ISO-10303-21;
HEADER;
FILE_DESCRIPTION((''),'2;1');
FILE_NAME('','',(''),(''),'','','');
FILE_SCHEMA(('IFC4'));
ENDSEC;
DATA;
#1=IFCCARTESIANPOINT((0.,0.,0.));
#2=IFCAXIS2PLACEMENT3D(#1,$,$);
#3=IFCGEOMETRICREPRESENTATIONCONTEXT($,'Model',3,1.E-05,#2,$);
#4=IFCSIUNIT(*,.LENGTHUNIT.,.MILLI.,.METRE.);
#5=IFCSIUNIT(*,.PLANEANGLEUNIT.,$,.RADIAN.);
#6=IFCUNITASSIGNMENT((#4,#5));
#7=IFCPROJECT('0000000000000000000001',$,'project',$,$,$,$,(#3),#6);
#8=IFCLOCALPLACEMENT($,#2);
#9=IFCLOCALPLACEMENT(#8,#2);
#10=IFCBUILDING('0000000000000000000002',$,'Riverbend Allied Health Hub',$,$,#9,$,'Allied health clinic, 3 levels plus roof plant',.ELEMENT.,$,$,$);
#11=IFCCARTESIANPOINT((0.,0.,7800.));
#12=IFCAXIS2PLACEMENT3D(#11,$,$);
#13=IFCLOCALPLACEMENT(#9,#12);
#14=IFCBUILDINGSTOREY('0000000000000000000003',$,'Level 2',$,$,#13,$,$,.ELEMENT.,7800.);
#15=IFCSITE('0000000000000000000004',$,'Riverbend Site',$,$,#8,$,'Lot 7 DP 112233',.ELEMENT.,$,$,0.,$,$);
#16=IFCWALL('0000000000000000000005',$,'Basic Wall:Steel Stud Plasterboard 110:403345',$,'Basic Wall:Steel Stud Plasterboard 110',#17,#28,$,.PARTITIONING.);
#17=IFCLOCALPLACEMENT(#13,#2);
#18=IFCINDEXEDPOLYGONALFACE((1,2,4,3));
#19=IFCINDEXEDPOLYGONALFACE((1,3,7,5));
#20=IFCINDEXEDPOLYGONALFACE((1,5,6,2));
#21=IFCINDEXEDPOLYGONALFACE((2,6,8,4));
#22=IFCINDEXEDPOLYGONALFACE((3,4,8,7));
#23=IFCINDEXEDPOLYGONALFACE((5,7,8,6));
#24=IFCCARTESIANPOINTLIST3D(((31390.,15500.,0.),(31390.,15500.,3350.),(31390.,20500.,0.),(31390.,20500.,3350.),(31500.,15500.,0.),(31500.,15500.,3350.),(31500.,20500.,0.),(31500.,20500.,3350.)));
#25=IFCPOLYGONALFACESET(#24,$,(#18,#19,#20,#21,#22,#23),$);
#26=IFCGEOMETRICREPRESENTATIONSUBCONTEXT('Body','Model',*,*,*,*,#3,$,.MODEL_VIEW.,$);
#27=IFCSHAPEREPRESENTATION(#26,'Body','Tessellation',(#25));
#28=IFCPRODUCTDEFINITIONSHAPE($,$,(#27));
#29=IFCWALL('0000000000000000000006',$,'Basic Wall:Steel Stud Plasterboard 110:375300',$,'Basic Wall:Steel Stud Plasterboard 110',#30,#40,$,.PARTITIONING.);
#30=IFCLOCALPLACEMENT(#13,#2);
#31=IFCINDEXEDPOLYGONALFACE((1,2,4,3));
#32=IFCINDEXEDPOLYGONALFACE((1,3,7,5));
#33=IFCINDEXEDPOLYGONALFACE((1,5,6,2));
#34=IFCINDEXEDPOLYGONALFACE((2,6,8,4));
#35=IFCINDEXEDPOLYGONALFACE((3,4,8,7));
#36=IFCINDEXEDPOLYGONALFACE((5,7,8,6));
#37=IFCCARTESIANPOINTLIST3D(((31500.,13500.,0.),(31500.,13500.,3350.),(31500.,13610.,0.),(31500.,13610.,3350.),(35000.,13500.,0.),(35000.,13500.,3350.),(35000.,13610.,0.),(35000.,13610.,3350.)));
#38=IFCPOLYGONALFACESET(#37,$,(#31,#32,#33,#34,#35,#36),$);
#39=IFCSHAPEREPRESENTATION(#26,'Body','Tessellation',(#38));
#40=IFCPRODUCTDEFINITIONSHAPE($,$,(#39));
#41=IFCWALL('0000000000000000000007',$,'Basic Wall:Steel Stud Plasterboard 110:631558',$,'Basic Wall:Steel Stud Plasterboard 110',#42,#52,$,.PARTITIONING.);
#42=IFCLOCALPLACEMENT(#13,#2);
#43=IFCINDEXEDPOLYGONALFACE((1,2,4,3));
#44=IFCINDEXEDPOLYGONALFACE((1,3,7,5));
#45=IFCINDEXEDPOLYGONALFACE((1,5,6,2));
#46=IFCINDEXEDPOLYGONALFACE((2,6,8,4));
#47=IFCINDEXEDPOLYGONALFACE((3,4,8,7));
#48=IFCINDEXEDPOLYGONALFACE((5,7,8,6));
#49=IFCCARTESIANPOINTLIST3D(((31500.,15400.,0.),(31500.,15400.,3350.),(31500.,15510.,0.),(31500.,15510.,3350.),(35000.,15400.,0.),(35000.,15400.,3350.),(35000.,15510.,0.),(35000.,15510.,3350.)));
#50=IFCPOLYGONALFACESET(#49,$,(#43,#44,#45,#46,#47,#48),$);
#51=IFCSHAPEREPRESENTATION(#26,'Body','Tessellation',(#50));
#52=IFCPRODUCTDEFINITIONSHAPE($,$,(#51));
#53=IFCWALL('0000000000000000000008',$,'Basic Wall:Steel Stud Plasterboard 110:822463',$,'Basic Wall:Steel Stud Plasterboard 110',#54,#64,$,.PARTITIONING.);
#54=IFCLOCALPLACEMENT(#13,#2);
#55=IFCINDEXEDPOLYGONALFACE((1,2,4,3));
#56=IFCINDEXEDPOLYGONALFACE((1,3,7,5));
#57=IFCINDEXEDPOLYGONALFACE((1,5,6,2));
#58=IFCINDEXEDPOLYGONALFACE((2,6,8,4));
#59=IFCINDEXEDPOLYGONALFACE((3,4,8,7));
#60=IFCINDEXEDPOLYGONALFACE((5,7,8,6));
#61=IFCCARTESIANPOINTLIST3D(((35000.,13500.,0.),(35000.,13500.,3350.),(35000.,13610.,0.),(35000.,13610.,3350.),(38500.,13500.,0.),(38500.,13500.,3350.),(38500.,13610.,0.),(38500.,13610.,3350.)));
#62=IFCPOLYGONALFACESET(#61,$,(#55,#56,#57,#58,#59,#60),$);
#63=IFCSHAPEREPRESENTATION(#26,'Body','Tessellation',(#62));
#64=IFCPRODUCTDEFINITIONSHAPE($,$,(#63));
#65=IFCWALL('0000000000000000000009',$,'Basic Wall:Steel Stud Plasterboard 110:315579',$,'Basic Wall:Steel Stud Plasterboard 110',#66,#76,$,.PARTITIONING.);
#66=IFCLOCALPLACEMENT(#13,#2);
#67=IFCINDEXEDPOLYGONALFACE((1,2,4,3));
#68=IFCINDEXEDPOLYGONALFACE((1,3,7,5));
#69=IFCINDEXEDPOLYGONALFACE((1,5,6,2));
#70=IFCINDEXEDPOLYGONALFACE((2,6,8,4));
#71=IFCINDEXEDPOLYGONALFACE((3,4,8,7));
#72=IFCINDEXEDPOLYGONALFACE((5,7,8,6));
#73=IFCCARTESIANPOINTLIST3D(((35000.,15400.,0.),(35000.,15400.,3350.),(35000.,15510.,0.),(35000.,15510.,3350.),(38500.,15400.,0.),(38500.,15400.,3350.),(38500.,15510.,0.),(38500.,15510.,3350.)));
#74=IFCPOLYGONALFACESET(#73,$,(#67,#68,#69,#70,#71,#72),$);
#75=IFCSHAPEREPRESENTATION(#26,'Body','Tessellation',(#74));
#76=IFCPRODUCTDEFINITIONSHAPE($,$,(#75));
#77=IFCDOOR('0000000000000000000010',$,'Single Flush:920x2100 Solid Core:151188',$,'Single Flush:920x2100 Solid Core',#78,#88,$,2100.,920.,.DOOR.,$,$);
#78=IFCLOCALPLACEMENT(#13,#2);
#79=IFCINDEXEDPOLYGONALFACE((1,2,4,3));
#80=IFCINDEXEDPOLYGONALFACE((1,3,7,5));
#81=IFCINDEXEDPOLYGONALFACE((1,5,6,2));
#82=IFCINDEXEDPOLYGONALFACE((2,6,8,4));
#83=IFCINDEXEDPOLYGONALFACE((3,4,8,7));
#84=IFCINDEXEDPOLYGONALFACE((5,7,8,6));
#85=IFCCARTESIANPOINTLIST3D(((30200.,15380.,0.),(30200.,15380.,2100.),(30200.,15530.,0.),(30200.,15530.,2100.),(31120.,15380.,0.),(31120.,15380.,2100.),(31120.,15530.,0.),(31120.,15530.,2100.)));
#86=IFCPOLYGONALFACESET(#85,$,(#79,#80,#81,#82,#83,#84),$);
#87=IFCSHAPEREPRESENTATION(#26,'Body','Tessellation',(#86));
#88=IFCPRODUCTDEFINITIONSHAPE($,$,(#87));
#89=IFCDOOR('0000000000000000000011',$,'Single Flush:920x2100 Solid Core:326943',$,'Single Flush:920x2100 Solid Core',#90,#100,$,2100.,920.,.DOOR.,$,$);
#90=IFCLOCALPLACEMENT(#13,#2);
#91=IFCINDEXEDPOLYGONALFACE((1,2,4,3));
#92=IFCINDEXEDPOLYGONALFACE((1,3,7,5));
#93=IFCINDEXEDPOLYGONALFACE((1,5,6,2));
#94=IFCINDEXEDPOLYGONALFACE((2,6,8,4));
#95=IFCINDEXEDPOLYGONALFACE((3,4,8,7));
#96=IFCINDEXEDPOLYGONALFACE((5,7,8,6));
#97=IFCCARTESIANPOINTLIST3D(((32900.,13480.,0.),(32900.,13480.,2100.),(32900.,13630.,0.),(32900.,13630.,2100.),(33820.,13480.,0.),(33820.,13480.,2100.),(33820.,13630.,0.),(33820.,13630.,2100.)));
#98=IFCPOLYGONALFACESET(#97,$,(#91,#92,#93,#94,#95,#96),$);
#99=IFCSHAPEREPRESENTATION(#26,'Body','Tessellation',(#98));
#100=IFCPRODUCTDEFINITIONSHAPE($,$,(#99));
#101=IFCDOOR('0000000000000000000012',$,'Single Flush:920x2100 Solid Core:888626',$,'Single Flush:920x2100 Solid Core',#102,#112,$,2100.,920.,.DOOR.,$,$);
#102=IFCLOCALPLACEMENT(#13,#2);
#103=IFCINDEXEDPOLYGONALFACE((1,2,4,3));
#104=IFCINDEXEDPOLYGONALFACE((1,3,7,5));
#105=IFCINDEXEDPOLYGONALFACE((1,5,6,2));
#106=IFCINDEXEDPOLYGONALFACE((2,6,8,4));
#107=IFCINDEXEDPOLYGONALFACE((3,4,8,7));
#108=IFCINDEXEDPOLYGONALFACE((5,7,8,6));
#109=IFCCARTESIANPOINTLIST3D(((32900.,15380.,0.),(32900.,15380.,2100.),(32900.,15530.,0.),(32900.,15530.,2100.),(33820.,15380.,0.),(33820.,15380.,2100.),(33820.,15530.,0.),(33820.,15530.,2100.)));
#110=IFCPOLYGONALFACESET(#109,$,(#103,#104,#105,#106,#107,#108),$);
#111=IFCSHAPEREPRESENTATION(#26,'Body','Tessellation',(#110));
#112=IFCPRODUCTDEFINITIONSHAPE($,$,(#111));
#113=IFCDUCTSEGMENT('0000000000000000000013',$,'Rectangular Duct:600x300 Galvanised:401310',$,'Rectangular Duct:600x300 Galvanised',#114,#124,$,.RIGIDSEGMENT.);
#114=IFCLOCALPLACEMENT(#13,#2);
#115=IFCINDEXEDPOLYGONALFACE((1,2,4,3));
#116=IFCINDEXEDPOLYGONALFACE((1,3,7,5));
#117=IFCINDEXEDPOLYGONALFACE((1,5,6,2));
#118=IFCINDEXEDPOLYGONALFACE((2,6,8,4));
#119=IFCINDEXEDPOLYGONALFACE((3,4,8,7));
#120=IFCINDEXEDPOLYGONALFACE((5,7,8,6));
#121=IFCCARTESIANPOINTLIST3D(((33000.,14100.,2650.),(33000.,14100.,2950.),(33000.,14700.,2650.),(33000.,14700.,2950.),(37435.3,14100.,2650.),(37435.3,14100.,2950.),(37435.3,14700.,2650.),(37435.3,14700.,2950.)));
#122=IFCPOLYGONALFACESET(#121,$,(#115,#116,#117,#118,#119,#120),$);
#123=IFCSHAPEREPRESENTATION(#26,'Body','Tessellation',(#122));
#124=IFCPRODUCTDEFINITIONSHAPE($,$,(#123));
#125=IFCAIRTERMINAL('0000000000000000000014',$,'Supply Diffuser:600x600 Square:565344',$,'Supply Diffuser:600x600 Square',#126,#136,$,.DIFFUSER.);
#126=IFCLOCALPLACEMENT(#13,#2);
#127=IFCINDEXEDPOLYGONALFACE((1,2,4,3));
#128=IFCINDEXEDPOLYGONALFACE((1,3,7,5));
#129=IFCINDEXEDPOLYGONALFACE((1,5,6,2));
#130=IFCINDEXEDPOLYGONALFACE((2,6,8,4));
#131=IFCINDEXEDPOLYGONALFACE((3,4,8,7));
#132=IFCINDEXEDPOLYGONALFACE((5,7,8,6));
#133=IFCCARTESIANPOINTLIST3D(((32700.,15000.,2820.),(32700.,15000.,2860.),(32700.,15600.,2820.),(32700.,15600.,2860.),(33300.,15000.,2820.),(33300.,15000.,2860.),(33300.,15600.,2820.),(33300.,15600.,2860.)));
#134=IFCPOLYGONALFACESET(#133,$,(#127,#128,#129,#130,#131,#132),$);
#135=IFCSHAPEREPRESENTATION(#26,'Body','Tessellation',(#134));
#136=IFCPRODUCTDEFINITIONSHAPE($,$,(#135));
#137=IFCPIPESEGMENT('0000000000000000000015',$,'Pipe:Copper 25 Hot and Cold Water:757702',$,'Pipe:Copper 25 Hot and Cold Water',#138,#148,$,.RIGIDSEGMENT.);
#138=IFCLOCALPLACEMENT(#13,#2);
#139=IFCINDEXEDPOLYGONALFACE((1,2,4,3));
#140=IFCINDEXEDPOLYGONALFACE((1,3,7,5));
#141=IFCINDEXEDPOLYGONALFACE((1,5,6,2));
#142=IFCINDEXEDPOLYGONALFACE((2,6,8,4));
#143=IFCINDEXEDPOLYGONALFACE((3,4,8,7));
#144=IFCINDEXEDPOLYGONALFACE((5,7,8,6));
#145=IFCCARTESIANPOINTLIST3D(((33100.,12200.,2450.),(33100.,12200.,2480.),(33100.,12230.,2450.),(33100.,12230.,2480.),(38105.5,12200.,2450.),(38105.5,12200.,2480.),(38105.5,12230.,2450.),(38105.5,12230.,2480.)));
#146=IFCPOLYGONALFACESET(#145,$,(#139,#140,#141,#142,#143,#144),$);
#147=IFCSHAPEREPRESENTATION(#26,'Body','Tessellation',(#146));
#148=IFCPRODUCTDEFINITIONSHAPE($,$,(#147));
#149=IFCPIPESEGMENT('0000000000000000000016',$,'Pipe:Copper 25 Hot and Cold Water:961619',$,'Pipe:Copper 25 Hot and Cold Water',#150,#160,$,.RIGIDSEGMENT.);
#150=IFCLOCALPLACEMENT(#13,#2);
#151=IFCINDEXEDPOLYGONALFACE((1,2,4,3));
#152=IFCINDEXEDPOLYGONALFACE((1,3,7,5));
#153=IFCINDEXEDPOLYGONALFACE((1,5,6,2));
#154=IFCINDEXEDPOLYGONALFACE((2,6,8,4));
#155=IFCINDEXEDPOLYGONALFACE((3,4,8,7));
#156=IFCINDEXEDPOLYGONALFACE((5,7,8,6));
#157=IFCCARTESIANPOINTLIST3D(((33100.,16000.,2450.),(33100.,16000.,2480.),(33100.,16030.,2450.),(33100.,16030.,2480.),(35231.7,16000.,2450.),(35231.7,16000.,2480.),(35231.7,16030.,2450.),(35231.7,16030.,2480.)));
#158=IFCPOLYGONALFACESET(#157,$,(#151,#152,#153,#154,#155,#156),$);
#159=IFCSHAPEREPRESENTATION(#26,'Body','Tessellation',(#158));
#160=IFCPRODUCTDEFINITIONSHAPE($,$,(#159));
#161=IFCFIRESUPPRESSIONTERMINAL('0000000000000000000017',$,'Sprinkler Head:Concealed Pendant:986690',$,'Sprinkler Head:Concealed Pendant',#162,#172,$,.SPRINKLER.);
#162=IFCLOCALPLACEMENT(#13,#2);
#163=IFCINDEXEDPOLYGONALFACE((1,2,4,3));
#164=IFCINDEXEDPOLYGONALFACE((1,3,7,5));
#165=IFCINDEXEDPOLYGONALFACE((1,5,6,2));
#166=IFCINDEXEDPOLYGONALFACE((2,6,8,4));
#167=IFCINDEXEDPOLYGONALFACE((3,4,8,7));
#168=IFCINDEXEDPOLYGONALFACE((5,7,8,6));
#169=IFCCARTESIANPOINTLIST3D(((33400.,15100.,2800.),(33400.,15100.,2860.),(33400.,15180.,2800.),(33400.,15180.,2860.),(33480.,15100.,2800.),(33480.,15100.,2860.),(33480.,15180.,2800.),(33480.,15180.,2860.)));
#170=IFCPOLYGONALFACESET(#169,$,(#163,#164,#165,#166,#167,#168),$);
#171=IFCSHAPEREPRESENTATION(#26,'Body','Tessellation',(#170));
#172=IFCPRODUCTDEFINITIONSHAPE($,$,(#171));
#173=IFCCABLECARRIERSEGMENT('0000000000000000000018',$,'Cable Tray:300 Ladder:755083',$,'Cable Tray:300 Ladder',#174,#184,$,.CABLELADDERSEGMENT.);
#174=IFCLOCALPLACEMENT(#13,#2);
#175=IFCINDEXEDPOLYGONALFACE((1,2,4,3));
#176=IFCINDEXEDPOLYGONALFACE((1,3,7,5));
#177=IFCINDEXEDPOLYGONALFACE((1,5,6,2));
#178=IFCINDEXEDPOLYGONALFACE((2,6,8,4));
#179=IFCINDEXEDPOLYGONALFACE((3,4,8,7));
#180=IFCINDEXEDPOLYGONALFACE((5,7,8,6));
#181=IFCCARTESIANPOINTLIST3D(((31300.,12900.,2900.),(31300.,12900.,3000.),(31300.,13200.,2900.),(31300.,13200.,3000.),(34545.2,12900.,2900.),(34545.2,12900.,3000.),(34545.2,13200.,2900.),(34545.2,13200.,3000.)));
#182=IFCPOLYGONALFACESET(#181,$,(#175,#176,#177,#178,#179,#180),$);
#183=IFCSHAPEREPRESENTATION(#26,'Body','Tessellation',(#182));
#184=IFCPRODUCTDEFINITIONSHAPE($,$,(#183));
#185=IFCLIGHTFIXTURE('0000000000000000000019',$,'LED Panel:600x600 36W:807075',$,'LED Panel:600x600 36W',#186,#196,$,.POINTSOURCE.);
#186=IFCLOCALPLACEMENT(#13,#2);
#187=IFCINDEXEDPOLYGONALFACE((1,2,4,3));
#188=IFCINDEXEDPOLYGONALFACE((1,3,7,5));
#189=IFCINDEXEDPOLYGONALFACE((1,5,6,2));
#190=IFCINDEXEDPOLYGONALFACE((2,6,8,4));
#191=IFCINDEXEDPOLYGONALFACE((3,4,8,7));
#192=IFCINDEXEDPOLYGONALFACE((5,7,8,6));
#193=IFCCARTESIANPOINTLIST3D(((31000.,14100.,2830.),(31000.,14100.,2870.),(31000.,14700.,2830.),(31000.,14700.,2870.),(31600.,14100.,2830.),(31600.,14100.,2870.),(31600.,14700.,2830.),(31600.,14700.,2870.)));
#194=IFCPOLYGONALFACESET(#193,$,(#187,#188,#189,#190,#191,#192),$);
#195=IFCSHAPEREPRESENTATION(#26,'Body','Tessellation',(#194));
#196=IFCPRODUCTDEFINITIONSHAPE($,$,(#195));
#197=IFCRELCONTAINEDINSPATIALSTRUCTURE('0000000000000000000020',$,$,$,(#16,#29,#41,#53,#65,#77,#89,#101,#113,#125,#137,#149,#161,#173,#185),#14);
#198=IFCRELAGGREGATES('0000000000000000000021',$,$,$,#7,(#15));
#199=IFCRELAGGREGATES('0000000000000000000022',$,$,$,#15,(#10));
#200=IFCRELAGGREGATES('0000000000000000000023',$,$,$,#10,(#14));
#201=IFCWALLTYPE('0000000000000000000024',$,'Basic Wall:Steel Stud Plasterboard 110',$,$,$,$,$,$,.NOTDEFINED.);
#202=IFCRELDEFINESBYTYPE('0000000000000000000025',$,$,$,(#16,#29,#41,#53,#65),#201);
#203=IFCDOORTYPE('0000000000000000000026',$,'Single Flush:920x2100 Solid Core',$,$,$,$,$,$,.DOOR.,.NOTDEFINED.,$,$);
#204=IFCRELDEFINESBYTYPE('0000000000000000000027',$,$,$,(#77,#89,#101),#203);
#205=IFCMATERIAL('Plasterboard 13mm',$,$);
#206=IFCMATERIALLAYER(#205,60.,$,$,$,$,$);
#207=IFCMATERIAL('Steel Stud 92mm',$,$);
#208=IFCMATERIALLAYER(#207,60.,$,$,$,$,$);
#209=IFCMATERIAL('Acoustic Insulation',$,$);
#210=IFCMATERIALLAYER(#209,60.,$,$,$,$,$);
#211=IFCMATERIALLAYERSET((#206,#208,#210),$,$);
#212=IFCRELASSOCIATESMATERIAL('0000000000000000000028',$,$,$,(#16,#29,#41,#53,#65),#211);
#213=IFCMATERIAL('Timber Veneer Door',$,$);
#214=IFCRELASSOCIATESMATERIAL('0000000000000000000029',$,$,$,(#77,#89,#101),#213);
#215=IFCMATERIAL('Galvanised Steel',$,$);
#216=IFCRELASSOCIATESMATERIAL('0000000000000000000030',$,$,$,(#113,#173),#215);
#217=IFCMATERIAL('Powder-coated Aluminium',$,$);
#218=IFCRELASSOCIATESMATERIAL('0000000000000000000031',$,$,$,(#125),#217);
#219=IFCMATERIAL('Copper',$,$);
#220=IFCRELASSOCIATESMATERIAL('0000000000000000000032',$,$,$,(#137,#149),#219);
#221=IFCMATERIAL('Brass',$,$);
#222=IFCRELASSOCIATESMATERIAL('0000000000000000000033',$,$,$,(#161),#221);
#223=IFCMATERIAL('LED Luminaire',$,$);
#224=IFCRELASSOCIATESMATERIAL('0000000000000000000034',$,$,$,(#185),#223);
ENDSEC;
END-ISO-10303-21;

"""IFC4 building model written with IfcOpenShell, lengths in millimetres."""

from ifc_helpers import new_model, si_unit, frame, frame_2d, origin, place, context, subcontext, project, spatial, rectangle, extrude, material, layer, layer_set, layer_usage, type_object, element, save


model = new_model("IFC4")

# Units and contexts
model_context = context("Model", 3, precision=1e-05, world=origin())
body_context = subcontext(model_context, "Body", "Model", "MODEL_VIEW")
ifc_project = project(units=[si_unit("LENGTHUNIT", "METRE", prefix="MILLI"), si_unit("PLANEANGLEUNIT", "RADIAN")], contexts=[model_context])

# Site, building, storey
site_placement = place(None, origin())
site = spatial("IfcSite", under=ifc_project, at=site_placement, Name="Riverbend Site", LongName="Lot 7 DP 112233", CompositionType="ELEMENT", RefElevation=0.0)
building_placement = place(site_placement, origin())
building = spatial("IfcBuilding", under=site, at=building_placement, Name="Riverbend Allied Health Hub", LongName="Allied health clinic, 3 levels plus roof plant", CompositionType="ELEMENT")
storey_placement = place(building_placement, frame((0.0, 0.0, 7800.0)))
storey = spatial("IfcBuildingStorey", under=building, at=storey_placement, Name="Level 2", CompositionType="ELEMENT", Elevation=7800.0)

# Walls
ifc_material_1 = material(Name="Plasterboard 13mm")
ifc_layer_1 = layer(ifc_material_1, 60.0)
ifc_material_2 = material(Name="Steel Stud 92mm")
ifc_layer_2 = layer(ifc_material_2, 60.0)
ifc_material_3 = material(Name="Acoustic Insulation")
ifc_layer_3 = layer(ifc_material_3, 60.0)
ifc_layer_set = layer_set([ifc_layer_1, ifc_layer_2, ifc_layer_3])
ifc_layer_usage = layer_usage(ifc_layer_set, "AXIS2", "POSITIVE", 0.0)
wall_type = type_object("IfcWallType", Name="Basic Wall:Steel Stud Plasterboard 110", PredefinedType="NOTDEFINED")
wall_placement = place(storey_placement, frame((31500.0, 15500.0, 0.0), z_axis=(0.0, 0.0, 1.0), x_axis=(0.0, 1.0, 0.0)))
element("IfcWall", 1, at=wall_placement, inside=storey, type_object=wall_type, material=ifc_layer_usage, Name="Basic Wall:Steel Stud Plasterboard 110:403345", ObjectType="Basic Wall:Steel Stud Plasterboard 110", PredefinedType="PARTITIONING", context=body_context, shape_type="SweptSolid", body=[
    extrude(rectangle(XDim=5000.0, YDim=110.0, at=frame_2d((2500.0, 55.0))), origin(), (0.0, 0.0, 1.0), 3350.0),
])
for number, where, name in (
    (2, (31500.0, 13500.0, 0.0), "Basic Wall:Steel Stud Plasterboard 110:375300"),
    (3, (31500.0, 15400.0, 0.0), "Basic Wall:Steel Stud Plasterboard 110:631558"),
    (4, (35000.0, 13500.0, 0.0), "Basic Wall:Steel Stud Plasterboard 110:822463"),
    (5, (35000.0, 15400.0, 0.0), "Basic Wall:Steel Stud Plasterboard 110:315579"),
):
    element("IfcWall", number, at=place(storey_placement, frame(where)), inside=storey, type_object=wall_type, material=ifc_layer_usage, Name=name, ObjectType="Basic Wall:Steel Stud Plasterboard 110", PredefinedType="PARTITIONING", context=body_context, shape_type="SweptSolid", body=[
        extrude(rectangle(XDim=3500.0, YDim=110.0, at=frame_2d((1750.0, 55.0))), origin(), (0.0, 0.0, 1.0), 3350.0),
    ])

# Doors
ifc_material_4 = material(Name="Timber Veneer Door")
door_type = type_object("IfcDoorType", Name="Single Flush:920x2100 Solid Core", OperationType="NOTDEFINED", PredefinedType="DOOR")
for number, where, name in (
    (6, (30200.0, 15380.0, 0.0), "Single Flush:920x2100 Solid Core:151188"),
    (7, (32900.0, 13480.0, 0.0), "Single Flush:920x2100 Solid Core:326943"),
    (8, (32900.0, 15380.0, 0.0), "Single Flush:920x2100 Solid Core:888626"),
):
    element("IfcDoor", number, at=place(storey_placement, frame(where)), inside=storey, type_object=door_type, material=ifc_material_4, Name=name, ObjectType="Single Flush:920x2100 Solid Core", OverallHeight=2100.0, OverallWidth=920.0, PredefinedType="DOOR", context=body_context, shape_type="SweptSolid", body=[
        extrude(rectangle(XDim=920.0, YDim=150.0, at=frame_2d((460.0, 75.0))), origin(), (0.0, 0.0, 1.0), 2100.0),
    ])

# Duct segment
ifc_material_5 = material(Name="Galvanised Steel")
duct_segment_placement = place(storey_placement, frame((33000.0, 14100.0, 2650.0)))
element("IfcDuctSegment", 9, at=duct_segment_placement, inside=storey, material=ifc_material_5, Name="Rectangular Duct:600x300 Galvanised:401310", ObjectType="Rectangular Duct:600x300 Galvanised", PredefinedType="RIGIDSEGMENT", context=body_context, shape_type="SweptSolid", body=[
    extrude(rectangle(XDim=4435.3, YDim=600.0, at=frame_2d((2217.6, 300.0))), origin(), (0.0, 0.0, 1.0), 300.0),
])

# Air terminal
ifc_material_6 = material(Name="Powder-coated Aluminium")
air_terminal_placement = place(storey_placement, frame((32700.0, 15000.0, 2820.0)))
element("IfcAirTerminal", 10, at=air_terminal_placement, inside=storey, material=ifc_material_6, Name="Supply Diffuser:600x600 Square:565344", ObjectType="Supply Diffuser:600x600 Square", PredefinedType="DIFFUSER", context=body_context, shape_type="SweptSolid", body=[
    extrude(rectangle(XDim=600.0, YDim=600.0, at=frame_2d((300.0, 300.0))), origin(), (0.0, 0.0, 1.0), 40.0),
])

# Pipe segments
ifc_material_7 = material(Name="Copper")
pipe_segment_1_placement = place(storey_placement, frame((33100.0, 12200.0, 2450.0)))
element("IfcPipeSegment", 11, at=pipe_segment_1_placement, inside=storey, material=ifc_material_7, Name="Pipe:Copper 25 Hot and Cold Water:757702", ObjectType="Pipe:Copper 25 Hot and Cold Water", PredefinedType="RIGIDSEGMENT", context=body_context, shape_type="SweptSolid", body=[
    extrude(rectangle(XDim=5005.5, YDim=30.0, at=frame_2d((2502.8, 15.0))), origin(), (0.0, 0.0, 1.0), 30.0),
])
pipe_segment_2_placement = place(storey_placement, frame((33100.0, 16000.0, 2450.0)))
element("IfcPipeSegment", 12, at=pipe_segment_2_placement, inside=storey, material=ifc_material_7, Name="Pipe:Copper 25 Hot and Cold Water:961619", ObjectType="Pipe:Copper 25 Hot and Cold Water", PredefinedType="RIGIDSEGMENT", context=body_context, shape_type="SweptSolid", body=[
    extrude(rectangle(XDim=2131.7, YDim=30.0, at=frame_2d((1065.8, 15.0))), origin(), (0.0, 0.0, 1.0), 30.0),
])

# Fire suppression terminal
ifc_material_8 = material(Name="Brass")
fire_suppression_terminal_placement = place(storey_placement, frame((33400.0, 15100.0, 2800.0)))
element("IfcFireSuppressionTerminal", 13, at=fire_suppression_terminal_placement, inside=storey, material=ifc_material_8, Name="Sprinkler Head:Concealed Pendant:986690", ObjectType="Sprinkler Head:Concealed Pendant", PredefinedType="SPRINKLER", context=body_context, shape_type="SweptSolid", body=[
    extrude(rectangle(XDim=80.0, YDim=80.0, at=frame_2d((40.0, 40.0))), origin(), (0.0, 0.0, 1.0), 60.0),
])

# Cable carrier segment
cable_carrier_segment_placement = place(storey_placement, frame((31300.0, 12900.0, 2900.0)))
element("IfcCableCarrierSegment", 14, at=cable_carrier_segment_placement, inside=storey, material=ifc_material_5, Name="Cable Tray:300 Ladder:755083", ObjectType="Cable Tray:300 Ladder", PredefinedType="CABLELADDERSEGMENT", context=body_context, shape_type="SweptSolid", body=[
    extrude(rectangle(XDim=3245.2, YDim=300.0, at=frame_2d((1622.6, 150.0))), origin(), (0.0, 0.0, 1.0), 100.0),
])

# Light fixture
ifc_material_9 = material(Name="LED Luminaire")
for number, where, name in (
    (15, (31000.0, 14100.0, 2830.0), "LED Panel:600x600 36W:807075"),
):
    element("IfcLightFixture", number, at=place(storey_placement, frame(where)), inside=storey, material=ifc_material_9, Name=name, ObjectType="LED Panel:600x600 36W", PredefinedType="POINTSOURCE", context=body_context, shape_type="SweptSolid", body=[
        extrude(rectangle(XDim=600.0, YDim=600.0, at=frame_2d((300.0, 300.0))), origin(), (0.0, 0.0, 1.0), 40.0),
    ])

save(model, "model.ifc")
